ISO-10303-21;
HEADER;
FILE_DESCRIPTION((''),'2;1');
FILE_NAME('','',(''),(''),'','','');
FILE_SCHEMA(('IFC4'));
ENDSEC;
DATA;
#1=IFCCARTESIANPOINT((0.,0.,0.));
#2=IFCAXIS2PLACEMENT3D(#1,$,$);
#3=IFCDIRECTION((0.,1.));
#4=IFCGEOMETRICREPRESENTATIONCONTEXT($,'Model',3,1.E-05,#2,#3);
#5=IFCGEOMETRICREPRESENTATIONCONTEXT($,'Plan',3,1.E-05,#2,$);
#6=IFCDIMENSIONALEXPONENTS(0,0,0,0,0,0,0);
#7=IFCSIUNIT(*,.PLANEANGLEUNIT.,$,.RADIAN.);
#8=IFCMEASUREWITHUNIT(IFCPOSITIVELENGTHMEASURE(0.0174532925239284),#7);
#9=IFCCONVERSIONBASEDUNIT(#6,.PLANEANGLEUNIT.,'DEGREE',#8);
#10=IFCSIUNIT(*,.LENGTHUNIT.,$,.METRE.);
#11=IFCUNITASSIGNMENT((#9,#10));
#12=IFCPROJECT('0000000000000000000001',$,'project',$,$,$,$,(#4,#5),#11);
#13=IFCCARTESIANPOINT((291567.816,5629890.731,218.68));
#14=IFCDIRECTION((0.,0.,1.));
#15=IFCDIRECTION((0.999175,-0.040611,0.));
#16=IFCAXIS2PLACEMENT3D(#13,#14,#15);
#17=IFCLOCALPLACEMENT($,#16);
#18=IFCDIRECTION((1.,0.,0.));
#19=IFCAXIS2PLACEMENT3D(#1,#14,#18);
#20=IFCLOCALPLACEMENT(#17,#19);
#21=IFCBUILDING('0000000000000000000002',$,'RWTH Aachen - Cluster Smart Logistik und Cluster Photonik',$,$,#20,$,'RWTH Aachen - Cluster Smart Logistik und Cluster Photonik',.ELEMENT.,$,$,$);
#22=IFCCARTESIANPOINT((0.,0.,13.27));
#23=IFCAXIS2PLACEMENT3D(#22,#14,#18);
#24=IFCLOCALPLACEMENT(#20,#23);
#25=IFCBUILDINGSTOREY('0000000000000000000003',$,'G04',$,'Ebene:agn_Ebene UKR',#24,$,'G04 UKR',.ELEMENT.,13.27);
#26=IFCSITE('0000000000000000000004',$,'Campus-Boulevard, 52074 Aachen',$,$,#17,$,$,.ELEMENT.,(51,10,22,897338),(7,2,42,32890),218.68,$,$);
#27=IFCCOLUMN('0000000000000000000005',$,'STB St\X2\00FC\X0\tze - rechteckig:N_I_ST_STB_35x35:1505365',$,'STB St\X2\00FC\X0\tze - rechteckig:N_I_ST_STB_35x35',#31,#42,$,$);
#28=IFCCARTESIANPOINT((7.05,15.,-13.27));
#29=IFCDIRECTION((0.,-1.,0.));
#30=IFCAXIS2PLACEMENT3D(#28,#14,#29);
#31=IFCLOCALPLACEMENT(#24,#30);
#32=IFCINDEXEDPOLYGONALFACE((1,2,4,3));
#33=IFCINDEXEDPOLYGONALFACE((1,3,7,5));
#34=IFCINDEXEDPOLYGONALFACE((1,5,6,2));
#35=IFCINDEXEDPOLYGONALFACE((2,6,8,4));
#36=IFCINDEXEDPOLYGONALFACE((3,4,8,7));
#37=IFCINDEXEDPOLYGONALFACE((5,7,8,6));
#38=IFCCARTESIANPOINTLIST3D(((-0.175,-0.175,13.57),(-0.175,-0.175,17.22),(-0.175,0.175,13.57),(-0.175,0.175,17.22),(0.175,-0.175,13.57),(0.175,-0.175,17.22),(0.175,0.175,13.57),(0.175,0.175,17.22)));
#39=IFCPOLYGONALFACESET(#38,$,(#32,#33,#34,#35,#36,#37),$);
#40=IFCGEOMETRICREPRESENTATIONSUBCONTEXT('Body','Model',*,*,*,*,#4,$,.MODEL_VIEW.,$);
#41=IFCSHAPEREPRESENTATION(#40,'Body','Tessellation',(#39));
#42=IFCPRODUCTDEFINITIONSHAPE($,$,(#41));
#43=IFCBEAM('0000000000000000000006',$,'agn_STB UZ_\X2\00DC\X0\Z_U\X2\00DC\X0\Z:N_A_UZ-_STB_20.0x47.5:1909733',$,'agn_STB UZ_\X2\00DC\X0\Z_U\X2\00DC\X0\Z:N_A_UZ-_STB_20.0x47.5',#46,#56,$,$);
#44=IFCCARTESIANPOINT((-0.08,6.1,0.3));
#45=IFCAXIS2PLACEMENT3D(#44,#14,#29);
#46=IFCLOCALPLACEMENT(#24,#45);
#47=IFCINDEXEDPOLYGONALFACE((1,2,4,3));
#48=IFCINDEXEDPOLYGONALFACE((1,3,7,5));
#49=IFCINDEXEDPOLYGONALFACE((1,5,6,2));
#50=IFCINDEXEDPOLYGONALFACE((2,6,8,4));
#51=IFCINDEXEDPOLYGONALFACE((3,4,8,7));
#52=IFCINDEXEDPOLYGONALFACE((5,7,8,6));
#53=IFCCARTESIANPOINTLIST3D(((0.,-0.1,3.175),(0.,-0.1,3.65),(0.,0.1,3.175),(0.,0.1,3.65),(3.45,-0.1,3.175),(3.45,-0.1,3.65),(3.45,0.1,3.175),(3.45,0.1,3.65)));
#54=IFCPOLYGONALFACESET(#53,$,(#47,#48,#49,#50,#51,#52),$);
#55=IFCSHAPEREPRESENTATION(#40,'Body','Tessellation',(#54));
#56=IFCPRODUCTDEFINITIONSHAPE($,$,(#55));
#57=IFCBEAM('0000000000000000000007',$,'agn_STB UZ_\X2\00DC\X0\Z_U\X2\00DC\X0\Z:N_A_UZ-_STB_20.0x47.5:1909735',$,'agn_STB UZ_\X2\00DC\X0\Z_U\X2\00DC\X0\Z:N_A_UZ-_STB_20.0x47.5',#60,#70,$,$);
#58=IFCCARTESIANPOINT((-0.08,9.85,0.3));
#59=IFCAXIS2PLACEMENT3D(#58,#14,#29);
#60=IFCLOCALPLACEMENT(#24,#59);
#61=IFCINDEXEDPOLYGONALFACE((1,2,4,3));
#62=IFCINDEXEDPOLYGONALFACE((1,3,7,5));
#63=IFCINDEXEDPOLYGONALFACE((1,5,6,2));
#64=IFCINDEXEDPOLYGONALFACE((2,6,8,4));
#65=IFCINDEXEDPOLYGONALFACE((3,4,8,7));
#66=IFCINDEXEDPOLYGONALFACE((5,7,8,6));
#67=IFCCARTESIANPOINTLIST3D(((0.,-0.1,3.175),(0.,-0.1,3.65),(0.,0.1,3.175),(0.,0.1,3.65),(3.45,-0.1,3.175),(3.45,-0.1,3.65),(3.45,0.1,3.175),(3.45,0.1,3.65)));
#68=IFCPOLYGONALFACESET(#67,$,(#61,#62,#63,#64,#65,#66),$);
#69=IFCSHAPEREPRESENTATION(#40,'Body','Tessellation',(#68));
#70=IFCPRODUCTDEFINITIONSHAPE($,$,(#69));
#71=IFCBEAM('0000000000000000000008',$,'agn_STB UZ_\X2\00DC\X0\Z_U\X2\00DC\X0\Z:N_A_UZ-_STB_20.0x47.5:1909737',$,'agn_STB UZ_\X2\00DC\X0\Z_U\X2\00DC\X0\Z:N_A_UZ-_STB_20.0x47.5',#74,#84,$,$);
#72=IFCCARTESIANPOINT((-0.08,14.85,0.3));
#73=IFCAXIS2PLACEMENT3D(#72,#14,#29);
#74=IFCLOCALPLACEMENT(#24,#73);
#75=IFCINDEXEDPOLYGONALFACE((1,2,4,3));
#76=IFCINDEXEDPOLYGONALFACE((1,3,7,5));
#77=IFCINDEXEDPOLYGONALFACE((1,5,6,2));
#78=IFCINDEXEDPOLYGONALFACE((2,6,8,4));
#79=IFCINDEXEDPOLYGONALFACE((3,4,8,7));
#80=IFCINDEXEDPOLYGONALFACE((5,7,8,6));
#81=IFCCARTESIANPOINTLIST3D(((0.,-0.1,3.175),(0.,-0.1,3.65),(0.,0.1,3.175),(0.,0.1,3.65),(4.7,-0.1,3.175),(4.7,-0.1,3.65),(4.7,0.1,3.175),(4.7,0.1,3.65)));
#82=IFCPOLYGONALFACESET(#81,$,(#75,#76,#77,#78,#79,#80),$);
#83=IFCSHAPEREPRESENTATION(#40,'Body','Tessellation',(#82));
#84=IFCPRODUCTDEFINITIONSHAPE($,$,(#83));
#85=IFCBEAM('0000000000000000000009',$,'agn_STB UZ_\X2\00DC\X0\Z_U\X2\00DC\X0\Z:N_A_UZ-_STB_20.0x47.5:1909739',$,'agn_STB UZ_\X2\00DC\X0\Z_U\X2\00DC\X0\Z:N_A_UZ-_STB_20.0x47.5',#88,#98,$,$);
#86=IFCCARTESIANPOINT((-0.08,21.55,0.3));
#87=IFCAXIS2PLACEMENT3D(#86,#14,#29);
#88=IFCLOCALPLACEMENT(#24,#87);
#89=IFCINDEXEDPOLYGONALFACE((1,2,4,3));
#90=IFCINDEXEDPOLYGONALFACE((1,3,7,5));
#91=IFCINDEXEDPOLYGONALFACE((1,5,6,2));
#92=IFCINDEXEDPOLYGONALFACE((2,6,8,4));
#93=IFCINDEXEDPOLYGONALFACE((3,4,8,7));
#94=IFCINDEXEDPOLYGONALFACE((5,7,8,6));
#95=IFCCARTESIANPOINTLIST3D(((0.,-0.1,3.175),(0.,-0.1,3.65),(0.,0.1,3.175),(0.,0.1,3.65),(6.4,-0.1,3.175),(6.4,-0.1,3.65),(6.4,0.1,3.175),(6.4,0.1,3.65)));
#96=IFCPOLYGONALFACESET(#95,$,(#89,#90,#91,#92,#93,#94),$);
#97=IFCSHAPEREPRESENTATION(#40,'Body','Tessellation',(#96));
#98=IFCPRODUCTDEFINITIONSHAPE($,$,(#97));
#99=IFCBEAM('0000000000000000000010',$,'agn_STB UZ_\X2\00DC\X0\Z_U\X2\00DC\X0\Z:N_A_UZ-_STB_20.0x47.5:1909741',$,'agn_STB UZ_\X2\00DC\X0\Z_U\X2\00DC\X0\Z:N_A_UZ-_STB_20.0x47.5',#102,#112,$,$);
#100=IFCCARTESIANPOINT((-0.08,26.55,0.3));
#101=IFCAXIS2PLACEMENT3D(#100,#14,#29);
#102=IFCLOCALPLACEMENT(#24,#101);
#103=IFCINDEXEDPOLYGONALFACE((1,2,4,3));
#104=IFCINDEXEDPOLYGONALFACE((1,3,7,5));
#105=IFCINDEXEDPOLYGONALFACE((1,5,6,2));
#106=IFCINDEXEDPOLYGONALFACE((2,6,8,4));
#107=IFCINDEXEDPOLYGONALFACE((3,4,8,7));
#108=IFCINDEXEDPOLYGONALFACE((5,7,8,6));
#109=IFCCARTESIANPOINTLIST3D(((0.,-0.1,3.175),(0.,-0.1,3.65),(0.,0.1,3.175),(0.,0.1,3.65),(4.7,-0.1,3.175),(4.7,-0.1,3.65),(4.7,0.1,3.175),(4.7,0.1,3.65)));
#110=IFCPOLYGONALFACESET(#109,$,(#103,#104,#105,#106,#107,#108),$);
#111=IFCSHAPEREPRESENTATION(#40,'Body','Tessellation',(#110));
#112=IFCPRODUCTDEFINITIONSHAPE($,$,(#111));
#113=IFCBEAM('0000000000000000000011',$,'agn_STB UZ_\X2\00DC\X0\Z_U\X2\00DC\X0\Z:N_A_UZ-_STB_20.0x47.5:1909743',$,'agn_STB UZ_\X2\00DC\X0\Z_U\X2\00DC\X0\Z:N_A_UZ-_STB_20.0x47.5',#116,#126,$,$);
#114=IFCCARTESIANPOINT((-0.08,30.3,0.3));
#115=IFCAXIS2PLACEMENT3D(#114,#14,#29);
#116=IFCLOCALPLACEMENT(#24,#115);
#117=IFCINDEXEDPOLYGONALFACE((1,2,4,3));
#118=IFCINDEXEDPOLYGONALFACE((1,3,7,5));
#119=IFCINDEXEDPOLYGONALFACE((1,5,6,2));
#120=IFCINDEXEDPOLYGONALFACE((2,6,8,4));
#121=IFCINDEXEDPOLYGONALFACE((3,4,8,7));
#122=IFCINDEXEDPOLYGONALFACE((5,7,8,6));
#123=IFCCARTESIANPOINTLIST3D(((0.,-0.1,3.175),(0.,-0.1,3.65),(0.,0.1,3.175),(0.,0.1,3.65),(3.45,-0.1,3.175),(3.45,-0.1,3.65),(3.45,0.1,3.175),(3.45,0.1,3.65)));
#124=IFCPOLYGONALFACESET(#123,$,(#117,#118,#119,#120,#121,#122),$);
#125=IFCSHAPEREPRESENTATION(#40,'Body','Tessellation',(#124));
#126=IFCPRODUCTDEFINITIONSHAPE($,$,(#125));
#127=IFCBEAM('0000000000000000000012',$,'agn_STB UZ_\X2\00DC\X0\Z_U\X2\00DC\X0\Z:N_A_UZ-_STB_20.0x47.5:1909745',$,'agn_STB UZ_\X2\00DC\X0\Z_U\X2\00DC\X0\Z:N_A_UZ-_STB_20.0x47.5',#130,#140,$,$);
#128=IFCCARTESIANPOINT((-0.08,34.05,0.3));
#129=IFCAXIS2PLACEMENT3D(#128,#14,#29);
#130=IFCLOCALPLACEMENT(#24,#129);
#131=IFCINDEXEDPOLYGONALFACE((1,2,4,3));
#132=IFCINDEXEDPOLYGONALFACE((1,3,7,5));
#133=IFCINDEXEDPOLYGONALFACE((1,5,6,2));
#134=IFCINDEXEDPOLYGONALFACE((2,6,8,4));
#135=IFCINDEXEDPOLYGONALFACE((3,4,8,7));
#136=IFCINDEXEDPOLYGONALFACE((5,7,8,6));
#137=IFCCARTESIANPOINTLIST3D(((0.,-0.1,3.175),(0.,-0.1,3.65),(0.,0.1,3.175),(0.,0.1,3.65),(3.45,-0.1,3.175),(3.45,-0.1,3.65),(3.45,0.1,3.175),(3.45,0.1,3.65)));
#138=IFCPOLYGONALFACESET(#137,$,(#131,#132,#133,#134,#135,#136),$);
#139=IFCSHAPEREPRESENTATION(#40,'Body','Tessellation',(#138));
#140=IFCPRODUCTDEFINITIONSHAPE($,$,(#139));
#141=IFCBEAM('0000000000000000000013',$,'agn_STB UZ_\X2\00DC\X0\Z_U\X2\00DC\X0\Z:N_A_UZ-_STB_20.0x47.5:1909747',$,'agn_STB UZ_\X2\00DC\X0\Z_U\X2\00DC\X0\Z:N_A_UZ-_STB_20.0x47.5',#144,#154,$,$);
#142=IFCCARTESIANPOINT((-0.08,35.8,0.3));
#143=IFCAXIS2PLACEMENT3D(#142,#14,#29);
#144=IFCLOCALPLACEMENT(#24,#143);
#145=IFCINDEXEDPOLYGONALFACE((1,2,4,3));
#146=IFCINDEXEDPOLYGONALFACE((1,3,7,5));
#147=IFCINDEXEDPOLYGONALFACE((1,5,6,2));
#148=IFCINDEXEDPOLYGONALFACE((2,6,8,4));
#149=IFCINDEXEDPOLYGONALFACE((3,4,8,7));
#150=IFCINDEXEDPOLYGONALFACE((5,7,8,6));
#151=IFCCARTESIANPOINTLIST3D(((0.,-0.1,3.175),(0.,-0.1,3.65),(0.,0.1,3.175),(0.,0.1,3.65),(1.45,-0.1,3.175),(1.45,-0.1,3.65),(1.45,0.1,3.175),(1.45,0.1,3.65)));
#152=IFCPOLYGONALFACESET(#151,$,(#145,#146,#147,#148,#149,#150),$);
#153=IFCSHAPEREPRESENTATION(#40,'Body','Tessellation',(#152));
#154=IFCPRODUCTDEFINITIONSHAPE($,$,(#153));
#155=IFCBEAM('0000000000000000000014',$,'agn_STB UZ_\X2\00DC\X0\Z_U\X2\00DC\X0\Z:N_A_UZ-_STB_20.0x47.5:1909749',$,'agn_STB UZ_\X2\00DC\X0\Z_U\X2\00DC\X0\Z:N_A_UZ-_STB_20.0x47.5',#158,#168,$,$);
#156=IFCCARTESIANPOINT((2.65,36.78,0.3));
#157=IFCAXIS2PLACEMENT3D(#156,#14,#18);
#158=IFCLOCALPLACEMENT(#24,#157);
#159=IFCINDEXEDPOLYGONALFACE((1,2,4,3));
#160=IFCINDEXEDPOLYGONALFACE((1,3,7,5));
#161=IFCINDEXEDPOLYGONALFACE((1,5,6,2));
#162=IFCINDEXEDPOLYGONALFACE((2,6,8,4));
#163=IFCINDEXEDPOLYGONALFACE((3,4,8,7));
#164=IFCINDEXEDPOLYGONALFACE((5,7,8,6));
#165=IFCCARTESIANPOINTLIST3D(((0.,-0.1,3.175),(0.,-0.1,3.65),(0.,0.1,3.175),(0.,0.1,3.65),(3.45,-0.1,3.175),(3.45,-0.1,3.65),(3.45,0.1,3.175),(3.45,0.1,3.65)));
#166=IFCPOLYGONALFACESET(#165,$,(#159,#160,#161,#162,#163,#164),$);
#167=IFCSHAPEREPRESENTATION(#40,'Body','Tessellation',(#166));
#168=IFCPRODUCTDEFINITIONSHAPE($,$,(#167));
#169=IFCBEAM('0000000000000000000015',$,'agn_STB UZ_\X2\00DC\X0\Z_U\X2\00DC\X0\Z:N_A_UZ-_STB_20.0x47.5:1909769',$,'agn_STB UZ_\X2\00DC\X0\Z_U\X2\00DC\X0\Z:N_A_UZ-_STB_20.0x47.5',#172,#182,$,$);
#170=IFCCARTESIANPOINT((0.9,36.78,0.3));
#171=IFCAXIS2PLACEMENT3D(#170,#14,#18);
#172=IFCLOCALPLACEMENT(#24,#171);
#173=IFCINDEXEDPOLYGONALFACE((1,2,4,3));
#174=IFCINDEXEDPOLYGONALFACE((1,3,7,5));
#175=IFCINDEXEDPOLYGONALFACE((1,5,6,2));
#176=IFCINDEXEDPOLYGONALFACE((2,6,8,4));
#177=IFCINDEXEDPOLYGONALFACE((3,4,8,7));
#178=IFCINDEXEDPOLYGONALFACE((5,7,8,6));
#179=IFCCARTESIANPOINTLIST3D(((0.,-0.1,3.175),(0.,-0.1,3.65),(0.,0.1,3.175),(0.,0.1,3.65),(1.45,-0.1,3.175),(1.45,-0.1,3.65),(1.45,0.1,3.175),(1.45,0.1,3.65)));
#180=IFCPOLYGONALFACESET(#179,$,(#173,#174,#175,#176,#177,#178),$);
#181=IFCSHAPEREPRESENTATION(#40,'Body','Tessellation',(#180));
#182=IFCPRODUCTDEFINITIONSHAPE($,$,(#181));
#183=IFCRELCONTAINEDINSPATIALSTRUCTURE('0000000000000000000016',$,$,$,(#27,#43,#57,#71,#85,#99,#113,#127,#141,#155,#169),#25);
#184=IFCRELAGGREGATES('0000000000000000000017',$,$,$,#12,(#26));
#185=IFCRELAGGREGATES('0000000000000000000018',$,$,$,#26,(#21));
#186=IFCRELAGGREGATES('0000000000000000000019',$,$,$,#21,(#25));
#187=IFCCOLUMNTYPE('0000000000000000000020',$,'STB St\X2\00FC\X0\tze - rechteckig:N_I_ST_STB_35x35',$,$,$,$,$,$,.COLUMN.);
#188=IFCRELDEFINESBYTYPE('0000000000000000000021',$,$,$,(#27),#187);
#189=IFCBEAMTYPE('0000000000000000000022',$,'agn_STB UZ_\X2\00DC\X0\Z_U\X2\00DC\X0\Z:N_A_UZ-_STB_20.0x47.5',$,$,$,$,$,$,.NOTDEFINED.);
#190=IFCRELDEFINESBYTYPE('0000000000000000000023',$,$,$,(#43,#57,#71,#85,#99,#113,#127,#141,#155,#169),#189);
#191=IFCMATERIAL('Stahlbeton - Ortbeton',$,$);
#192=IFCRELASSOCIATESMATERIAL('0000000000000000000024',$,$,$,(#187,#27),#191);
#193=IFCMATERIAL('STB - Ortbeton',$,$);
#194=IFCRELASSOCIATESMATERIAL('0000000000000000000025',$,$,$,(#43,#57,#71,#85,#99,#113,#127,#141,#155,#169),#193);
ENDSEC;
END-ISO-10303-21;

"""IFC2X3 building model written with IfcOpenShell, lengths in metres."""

from ifc_helpers import new_model, entity, si_unit, converted_unit, direction, frame, frame_2d, origin, origin_with_axes, origin_2d_with_axis, place, context, subcontext, project, spatial, rectangle, extrude, source, transform, mapped, material, type_object, element, save


model = new_model("IFC2X3")

# Units and contexts
model_context = context("Model", 3, precision=1e-05, world=origin(), true_north=direction((0.0, 1.0)))
plan_context = context("Plan", 3, precision=1e-05, world=origin())
body_context = subcontext(model_context, "Body", "Model", "MODEL_VIEW")
ifc_project = project(units=[converted_unit("PLANEANGLEUNIT", "DEGREE", entity("IfcPositiveLengthMeasure", 0.0174532925239284), si_unit("PLANEANGLEUNIT", "RADIAN"), dimensions=[0, 0, 0, 0, 0, 0, 0]), si_unit("LENGTHUNIT", "METRE")], contexts=[model_context, plan_context])

# Site, building, storey
site_placement = place(None, frame((291567.816, 5629890.731, 218.68), z_axis=(0.0, 0.0, 1.0), x_axis=(0.999175, -0.040611, 0.0)))
site = spatial("IfcSite", under=ifc_project, at=site_placement, Name="Campus-Boulevard, 52074 Aachen", CompositionType="ELEMENT", RefLatitude=(51, 10, 22, 897338), RefLongitude=(7, 2, 42, 32890), RefElevation=218.68)
building_placement = place(site_placement, origin_with_axes())
building = spatial("IfcBuilding", under=site, at=building_placement, Name="RWTH Aachen - Cluster Smart Logistik und Cluster Photonik", LongName="RWTH Aachen - Cluster Smart Logistik und Cluster Photonik", CompositionType="ELEMENT")
storey_placement = place(building_placement, frame((0.0, 0.0, 13.27), z_axis=(0.0, 0.0, 1.0), x_axis=(1.0, 0.0, 0.0)))
storey = spatial("IfcBuildingStorey", under=building, at=storey_placement, Name="G04", ObjectType="Ebene:agn_Ebene UKR", LongName="G04 UKR", CompositionType="ELEMENT", Elevation=13.27)

# Column
ifc_material_1 = material(Name="Stahlbeton - Ortbeton")
column_type = type_object("IfcColumnType", Name="STB Stütze - rechteckig:N_I_ST_STB_35x35", PredefinedType="COLUMN", material=ifc_material_1)
shared_shape = source(origin(), body_context, "Body", "SweptSolid", [
    extrude(rectangle(XDim=0.35, YDim=0.35, at=origin_2d_with_axis()), frame((0.0, 0.0, 13.57), z_axis=(0.0, 0.0, 1.0), x_axis=(0.0, -1.0, 0.0)), (0.0, 0.0, 1.0), 3.65),
])
column_placement = place(storey_placement, frame((7.05, 15.0, -13.27), z_axis=(0.0, 0.0, 1.0), x_axis=(0.0, -1.0, 0.0)))
element("IfcColumn", 1, at=column_placement, inside=storey, type_object=column_type, material=ifc_material_1, Name="STB Stütze - rechteckig:N_I_ST_STB_35x35:1505365", ObjectType="STB Stütze - rechteckig:N_I_ST_STB_35x35", context=body_context, shape_type="MappedRepresentation", body=[
    mapped(shared_shape, transform((0.0, 0.0, 0.0), scale=1.0)),
])

# Beams
ifc_material_2 = material(Name="STB - Ortbeton")
beam_type_1 = type_object("IfcBeamType", Name="agn_STB UZ_ÜZ_UÜZ:N_A_UZ-_STB_20.0x47.5", PredefinedType="NOTDEFINED")
for number, where, z_axis, x_axis, name in (
    (2, (-0.08, 6.1, 0.3), (0.0, 0.0, 1.0), (0.0, -1.0, 0.0), "agn_STB UZ_ÜZ_UÜZ:N_A_UZ-_STB_20.0x47.5:1909733"),
    (3, (-0.08, 9.85, 0.3), (0.0, 0.0, 1.0), (0.0, -1.0, 0.0), "agn_STB UZ_ÜZ_UÜZ:N_A_UZ-_STB_20.0x47.5:1909735"),
):
    element("IfcBeam", number, at=place(storey_placement, frame(where, z_axis=z_axis, x_axis=x_axis)), inside=storey, type_object=beam_type_1, material=ifc_material_2, Name=name, ObjectType="agn_STB UZ_ÜZ_UÜZ:N_A_UZ-_STB_20.0x47.5", context=body_context, shape_type="SweptSolid", body=[
        extrude(rectangle(XDim=0.475, YDim=0.2, at=frame_2d((0.0, 0.0), x_axis=(1.0, 0.0))), frame((0.0, 0.0, 3.4125), z_axis=(1.0, 0.0, 0.0), x_axis=(0.0, 0.0, -1.0)), (0.0, 0.0, 1.0), 3.45),
    ])
beam_1_placement = place(storey_placement, frame((-0.08, 14.85, 0.3), z_axis=(0.0, 0.0, 1.0), x_axis=(0.0, -1.0, 0.0)))
element("IfcBeam", 4, at=beam_1_placement, inside=storey, type_object=beam_type_1, material=ifc_material_2, Name="agn_STB UZ_ÜZ_UÜZ:N_A_UZ-_STB_20.0x47.5:1909737", ObjectType="agn_STB UZ_ÜZ_UÜZ:N_A_UZ-_STB_20.0x47.5", context=body_context, shape_type="SweptSolid", body=[
    extrude(rectangle(XDim=0.475, YDim=0.2, at=frame_2d((0.0, 0.0), x_axis=(1.0, 0.0))), frame((0.0, 0.0, 3.4125), z_axis=(1.0, 0.0, 0.0), x_axis=(0.0, 0.0, -1.0)), (0.0, 0.0, 1.0), 4.7),
])
beam_2_placement = place(storey_placement, frame((-0.08, 21.55, 0.3), z_axis=(0.0, 0.0, 1.0), x_axis=(0.0, -1.0, 0.0)))
element("IfcBeam", 5, at=beam_2_placement, inside=storey, type_object=beam_type_1, material=ifc_material_2, Name="agn_STB UZ_ÜZ_UÜZ:N_A_UZ-_STB_20.0x47.5:1909739", ObjectType="agn_STB UZ_ÜZ_UÜZ:N_A_UZ-_STB_20.0x47.5", context=body_context, shape_type="SweptSolid", body=[
    extrude(rectangle(XDim=0.475, YDim=0.2, at=frame_2d((0.0, 0.0), x_axis=(1.0, 0.0))), frame((0.0, 0.0, 3.4125), z_axis=(1.0, 0.0, 0.0), x_axis=(0.0, 0.0, -1.0)), (0.0, 0.0, 1.0), 6.4),
])
beam_3_placement = place(storey_placement, frame((-0.08, 26.55, 0.3), z_axis=(0.0, 0.0, 1.0), x_axis=(0.0, -1.0, 0.0)))
element("IfcBeam", 6, at=beam_3_placement, inside=storey, type_object=beam_type_1, material=ifc_material_2, Name="agn_STB UZ_ÜZ_UÜZ:N_A_UZ-_STB_20.0x47.5:1909741", ObjectType="agn_STB UZ_ÜZ_UÜZ:N_A_UZ-_STB_20.0x47.5", context=body_context, shape_type="SweptSolid", body=[
    extrude(rectangle(XDim=0.475, YDim=0.2, at=frame_2d((0.0, 0.0), x_axis=(1.0, 0.0))), frame((0.0, 0.0, 3.4125), z_axis=(1.0, 0.0, 0.0), x_axis=(0.0, 0.0, -1.0)), (0.0, 0.0, 1.0), 4.7),
])
for number, where, z_axis, x_axis, name in (
    (7, (-0.08, 30.3, 0.3), (0.0, 0.0, 1.0), (0.0, -1.0, 0.0), "agn_STB UZ_ÜZ_UÜZ:N_A_UZ-_STB_20.0x47.5:1909743"),
    (8, (-0.08, 34.05, 0.3), (0.0, 0.0, 1.0), (0.0, -1.0, 0.0), "agn_STB UZ_ÜZ_UÜZ:N_A_UZ-_STB_20.0x47.5:1909745"),
):
    element("IfcBeam", number, at=place(storey_placement, frame(where, z_axis=z_axis, x_axis=x_axis)), inside=storey, type_object=beam_type_1, material=ifc_material_2, Name=name, ObjectType="agn_STB UZ_ÜZ_UÜZ:N_A_UZ-_STB_20.0x47.5", context=body_context, shape_type="SweptSolid", body=[
        extrude(rectangle(XDim=0.475, YDim=0.2, at=frame_2d((0.0, 0.0), x_axis=(1.0, 0.0))), frame((0.0, 0.0, 3.4125), z_axis=(1.0, 0.0, 0.0), x_axis=(0.0, 0.0, -1.0)), (0.0, 0.0, 1.0), 3.45),
    ])
beam_4_placement = place(storey_placement, frame((-0.08, 35.8, 0.3), z_axis=(0.0, 0.0, 1.0), x_axis=(0.0, -1.0, 0.0)))
element("IfcBeam", 9, at=beam_4_placement, inside=storey, type_object=beam_type_1, material=ifc_material_2, Name="agn_STB UZ_ÜZ_UÜZ:N_A_UZ-_STB_20.0x47.5:1909747", ObjectType="agn_STB UZ_ÜZ_UÜZ:N_A_UZ-_STB_20.0x47.5", context=body_context, shape_type="SweptSolid", body=[
    extrude(rectangle(XDim=0.475, YDim=0.2, at=frame_2d((0.0, 0.0), x_axis=(1.0, 0.0))), frame((0.0, 0.0, 3.4125), z_axis=(1.0, 0.0, 0.0), x_axis=(0.0, 0.0, -1.0)), (0.0, 0.0, 1.0), 1.45),
])
beam_5_placement = place(storey_placement, frame((2.65, 36.78, 0.3), z_axis=(0.0, 0.0, 1.0), x_axis=(1.0, 0.0, 0.0)))
element("IfcBeam", 10, at=beam_5_placement, inside=storey, type_object=beam_type_1, material=ifc_material_2, Name="agn_STB UZ_ÜZ_UÜZ:N_A_UZ-_STB_20.0x47.5:1909749", ObjectType="agn_STB UZ_ÜZ_UÜZ:N_A_UZ-_STB_20.0x47.5", context=body_context, shape_type="SweptSolid", body=[
    extrude(rectangle(XDim=0.475, YDim=0.2, at=frame_2d((0.0, 0.0), x_axis=(1.0, 0.0))), frame((0.0, 0.0, 3.4125), z_axis=(1.0, 0.0, 0.0), x_axis=(0.0, 0.0, -1.0)), (0.0, 0.0, 1.0), 3.45),
])
beam_6_placement = place(storey_placement, frame((0.9, 36.78, 0.3), z_axis=(0.0, 0.0, 1.0), x_axis=(1.0, 0.0, 0.0)))
element("IfcBeam", 11, at=beam_6_placement, inside=storey, type_object=beam_type_1, material=ifc_material_2, Name="agn_STB UZ_ÜZ_UÜZ:N_A_UZ-_STB_20.0x47.5:1909769", ObjectType="agn_STB UZ_ÜZ_UÜZ:N_A_UZ-_STB_20.0x47.5", context=body_context, shape_type="SweptSolid", body=[
    extrude(rectangle(XDim=0.475, YDim=0.2, at=frame_2d((0.0, 0.0), x_axis=(1.0, 0.0))), frame((0.0, 0.0, 3.4125), z_axis=(1.0, 0.0, 0.0), x_axis=(0.0, 0.0, -1.0)), (0.0, 0.0, 1.0), 1.45),
])

save(model, "model.ifc")
